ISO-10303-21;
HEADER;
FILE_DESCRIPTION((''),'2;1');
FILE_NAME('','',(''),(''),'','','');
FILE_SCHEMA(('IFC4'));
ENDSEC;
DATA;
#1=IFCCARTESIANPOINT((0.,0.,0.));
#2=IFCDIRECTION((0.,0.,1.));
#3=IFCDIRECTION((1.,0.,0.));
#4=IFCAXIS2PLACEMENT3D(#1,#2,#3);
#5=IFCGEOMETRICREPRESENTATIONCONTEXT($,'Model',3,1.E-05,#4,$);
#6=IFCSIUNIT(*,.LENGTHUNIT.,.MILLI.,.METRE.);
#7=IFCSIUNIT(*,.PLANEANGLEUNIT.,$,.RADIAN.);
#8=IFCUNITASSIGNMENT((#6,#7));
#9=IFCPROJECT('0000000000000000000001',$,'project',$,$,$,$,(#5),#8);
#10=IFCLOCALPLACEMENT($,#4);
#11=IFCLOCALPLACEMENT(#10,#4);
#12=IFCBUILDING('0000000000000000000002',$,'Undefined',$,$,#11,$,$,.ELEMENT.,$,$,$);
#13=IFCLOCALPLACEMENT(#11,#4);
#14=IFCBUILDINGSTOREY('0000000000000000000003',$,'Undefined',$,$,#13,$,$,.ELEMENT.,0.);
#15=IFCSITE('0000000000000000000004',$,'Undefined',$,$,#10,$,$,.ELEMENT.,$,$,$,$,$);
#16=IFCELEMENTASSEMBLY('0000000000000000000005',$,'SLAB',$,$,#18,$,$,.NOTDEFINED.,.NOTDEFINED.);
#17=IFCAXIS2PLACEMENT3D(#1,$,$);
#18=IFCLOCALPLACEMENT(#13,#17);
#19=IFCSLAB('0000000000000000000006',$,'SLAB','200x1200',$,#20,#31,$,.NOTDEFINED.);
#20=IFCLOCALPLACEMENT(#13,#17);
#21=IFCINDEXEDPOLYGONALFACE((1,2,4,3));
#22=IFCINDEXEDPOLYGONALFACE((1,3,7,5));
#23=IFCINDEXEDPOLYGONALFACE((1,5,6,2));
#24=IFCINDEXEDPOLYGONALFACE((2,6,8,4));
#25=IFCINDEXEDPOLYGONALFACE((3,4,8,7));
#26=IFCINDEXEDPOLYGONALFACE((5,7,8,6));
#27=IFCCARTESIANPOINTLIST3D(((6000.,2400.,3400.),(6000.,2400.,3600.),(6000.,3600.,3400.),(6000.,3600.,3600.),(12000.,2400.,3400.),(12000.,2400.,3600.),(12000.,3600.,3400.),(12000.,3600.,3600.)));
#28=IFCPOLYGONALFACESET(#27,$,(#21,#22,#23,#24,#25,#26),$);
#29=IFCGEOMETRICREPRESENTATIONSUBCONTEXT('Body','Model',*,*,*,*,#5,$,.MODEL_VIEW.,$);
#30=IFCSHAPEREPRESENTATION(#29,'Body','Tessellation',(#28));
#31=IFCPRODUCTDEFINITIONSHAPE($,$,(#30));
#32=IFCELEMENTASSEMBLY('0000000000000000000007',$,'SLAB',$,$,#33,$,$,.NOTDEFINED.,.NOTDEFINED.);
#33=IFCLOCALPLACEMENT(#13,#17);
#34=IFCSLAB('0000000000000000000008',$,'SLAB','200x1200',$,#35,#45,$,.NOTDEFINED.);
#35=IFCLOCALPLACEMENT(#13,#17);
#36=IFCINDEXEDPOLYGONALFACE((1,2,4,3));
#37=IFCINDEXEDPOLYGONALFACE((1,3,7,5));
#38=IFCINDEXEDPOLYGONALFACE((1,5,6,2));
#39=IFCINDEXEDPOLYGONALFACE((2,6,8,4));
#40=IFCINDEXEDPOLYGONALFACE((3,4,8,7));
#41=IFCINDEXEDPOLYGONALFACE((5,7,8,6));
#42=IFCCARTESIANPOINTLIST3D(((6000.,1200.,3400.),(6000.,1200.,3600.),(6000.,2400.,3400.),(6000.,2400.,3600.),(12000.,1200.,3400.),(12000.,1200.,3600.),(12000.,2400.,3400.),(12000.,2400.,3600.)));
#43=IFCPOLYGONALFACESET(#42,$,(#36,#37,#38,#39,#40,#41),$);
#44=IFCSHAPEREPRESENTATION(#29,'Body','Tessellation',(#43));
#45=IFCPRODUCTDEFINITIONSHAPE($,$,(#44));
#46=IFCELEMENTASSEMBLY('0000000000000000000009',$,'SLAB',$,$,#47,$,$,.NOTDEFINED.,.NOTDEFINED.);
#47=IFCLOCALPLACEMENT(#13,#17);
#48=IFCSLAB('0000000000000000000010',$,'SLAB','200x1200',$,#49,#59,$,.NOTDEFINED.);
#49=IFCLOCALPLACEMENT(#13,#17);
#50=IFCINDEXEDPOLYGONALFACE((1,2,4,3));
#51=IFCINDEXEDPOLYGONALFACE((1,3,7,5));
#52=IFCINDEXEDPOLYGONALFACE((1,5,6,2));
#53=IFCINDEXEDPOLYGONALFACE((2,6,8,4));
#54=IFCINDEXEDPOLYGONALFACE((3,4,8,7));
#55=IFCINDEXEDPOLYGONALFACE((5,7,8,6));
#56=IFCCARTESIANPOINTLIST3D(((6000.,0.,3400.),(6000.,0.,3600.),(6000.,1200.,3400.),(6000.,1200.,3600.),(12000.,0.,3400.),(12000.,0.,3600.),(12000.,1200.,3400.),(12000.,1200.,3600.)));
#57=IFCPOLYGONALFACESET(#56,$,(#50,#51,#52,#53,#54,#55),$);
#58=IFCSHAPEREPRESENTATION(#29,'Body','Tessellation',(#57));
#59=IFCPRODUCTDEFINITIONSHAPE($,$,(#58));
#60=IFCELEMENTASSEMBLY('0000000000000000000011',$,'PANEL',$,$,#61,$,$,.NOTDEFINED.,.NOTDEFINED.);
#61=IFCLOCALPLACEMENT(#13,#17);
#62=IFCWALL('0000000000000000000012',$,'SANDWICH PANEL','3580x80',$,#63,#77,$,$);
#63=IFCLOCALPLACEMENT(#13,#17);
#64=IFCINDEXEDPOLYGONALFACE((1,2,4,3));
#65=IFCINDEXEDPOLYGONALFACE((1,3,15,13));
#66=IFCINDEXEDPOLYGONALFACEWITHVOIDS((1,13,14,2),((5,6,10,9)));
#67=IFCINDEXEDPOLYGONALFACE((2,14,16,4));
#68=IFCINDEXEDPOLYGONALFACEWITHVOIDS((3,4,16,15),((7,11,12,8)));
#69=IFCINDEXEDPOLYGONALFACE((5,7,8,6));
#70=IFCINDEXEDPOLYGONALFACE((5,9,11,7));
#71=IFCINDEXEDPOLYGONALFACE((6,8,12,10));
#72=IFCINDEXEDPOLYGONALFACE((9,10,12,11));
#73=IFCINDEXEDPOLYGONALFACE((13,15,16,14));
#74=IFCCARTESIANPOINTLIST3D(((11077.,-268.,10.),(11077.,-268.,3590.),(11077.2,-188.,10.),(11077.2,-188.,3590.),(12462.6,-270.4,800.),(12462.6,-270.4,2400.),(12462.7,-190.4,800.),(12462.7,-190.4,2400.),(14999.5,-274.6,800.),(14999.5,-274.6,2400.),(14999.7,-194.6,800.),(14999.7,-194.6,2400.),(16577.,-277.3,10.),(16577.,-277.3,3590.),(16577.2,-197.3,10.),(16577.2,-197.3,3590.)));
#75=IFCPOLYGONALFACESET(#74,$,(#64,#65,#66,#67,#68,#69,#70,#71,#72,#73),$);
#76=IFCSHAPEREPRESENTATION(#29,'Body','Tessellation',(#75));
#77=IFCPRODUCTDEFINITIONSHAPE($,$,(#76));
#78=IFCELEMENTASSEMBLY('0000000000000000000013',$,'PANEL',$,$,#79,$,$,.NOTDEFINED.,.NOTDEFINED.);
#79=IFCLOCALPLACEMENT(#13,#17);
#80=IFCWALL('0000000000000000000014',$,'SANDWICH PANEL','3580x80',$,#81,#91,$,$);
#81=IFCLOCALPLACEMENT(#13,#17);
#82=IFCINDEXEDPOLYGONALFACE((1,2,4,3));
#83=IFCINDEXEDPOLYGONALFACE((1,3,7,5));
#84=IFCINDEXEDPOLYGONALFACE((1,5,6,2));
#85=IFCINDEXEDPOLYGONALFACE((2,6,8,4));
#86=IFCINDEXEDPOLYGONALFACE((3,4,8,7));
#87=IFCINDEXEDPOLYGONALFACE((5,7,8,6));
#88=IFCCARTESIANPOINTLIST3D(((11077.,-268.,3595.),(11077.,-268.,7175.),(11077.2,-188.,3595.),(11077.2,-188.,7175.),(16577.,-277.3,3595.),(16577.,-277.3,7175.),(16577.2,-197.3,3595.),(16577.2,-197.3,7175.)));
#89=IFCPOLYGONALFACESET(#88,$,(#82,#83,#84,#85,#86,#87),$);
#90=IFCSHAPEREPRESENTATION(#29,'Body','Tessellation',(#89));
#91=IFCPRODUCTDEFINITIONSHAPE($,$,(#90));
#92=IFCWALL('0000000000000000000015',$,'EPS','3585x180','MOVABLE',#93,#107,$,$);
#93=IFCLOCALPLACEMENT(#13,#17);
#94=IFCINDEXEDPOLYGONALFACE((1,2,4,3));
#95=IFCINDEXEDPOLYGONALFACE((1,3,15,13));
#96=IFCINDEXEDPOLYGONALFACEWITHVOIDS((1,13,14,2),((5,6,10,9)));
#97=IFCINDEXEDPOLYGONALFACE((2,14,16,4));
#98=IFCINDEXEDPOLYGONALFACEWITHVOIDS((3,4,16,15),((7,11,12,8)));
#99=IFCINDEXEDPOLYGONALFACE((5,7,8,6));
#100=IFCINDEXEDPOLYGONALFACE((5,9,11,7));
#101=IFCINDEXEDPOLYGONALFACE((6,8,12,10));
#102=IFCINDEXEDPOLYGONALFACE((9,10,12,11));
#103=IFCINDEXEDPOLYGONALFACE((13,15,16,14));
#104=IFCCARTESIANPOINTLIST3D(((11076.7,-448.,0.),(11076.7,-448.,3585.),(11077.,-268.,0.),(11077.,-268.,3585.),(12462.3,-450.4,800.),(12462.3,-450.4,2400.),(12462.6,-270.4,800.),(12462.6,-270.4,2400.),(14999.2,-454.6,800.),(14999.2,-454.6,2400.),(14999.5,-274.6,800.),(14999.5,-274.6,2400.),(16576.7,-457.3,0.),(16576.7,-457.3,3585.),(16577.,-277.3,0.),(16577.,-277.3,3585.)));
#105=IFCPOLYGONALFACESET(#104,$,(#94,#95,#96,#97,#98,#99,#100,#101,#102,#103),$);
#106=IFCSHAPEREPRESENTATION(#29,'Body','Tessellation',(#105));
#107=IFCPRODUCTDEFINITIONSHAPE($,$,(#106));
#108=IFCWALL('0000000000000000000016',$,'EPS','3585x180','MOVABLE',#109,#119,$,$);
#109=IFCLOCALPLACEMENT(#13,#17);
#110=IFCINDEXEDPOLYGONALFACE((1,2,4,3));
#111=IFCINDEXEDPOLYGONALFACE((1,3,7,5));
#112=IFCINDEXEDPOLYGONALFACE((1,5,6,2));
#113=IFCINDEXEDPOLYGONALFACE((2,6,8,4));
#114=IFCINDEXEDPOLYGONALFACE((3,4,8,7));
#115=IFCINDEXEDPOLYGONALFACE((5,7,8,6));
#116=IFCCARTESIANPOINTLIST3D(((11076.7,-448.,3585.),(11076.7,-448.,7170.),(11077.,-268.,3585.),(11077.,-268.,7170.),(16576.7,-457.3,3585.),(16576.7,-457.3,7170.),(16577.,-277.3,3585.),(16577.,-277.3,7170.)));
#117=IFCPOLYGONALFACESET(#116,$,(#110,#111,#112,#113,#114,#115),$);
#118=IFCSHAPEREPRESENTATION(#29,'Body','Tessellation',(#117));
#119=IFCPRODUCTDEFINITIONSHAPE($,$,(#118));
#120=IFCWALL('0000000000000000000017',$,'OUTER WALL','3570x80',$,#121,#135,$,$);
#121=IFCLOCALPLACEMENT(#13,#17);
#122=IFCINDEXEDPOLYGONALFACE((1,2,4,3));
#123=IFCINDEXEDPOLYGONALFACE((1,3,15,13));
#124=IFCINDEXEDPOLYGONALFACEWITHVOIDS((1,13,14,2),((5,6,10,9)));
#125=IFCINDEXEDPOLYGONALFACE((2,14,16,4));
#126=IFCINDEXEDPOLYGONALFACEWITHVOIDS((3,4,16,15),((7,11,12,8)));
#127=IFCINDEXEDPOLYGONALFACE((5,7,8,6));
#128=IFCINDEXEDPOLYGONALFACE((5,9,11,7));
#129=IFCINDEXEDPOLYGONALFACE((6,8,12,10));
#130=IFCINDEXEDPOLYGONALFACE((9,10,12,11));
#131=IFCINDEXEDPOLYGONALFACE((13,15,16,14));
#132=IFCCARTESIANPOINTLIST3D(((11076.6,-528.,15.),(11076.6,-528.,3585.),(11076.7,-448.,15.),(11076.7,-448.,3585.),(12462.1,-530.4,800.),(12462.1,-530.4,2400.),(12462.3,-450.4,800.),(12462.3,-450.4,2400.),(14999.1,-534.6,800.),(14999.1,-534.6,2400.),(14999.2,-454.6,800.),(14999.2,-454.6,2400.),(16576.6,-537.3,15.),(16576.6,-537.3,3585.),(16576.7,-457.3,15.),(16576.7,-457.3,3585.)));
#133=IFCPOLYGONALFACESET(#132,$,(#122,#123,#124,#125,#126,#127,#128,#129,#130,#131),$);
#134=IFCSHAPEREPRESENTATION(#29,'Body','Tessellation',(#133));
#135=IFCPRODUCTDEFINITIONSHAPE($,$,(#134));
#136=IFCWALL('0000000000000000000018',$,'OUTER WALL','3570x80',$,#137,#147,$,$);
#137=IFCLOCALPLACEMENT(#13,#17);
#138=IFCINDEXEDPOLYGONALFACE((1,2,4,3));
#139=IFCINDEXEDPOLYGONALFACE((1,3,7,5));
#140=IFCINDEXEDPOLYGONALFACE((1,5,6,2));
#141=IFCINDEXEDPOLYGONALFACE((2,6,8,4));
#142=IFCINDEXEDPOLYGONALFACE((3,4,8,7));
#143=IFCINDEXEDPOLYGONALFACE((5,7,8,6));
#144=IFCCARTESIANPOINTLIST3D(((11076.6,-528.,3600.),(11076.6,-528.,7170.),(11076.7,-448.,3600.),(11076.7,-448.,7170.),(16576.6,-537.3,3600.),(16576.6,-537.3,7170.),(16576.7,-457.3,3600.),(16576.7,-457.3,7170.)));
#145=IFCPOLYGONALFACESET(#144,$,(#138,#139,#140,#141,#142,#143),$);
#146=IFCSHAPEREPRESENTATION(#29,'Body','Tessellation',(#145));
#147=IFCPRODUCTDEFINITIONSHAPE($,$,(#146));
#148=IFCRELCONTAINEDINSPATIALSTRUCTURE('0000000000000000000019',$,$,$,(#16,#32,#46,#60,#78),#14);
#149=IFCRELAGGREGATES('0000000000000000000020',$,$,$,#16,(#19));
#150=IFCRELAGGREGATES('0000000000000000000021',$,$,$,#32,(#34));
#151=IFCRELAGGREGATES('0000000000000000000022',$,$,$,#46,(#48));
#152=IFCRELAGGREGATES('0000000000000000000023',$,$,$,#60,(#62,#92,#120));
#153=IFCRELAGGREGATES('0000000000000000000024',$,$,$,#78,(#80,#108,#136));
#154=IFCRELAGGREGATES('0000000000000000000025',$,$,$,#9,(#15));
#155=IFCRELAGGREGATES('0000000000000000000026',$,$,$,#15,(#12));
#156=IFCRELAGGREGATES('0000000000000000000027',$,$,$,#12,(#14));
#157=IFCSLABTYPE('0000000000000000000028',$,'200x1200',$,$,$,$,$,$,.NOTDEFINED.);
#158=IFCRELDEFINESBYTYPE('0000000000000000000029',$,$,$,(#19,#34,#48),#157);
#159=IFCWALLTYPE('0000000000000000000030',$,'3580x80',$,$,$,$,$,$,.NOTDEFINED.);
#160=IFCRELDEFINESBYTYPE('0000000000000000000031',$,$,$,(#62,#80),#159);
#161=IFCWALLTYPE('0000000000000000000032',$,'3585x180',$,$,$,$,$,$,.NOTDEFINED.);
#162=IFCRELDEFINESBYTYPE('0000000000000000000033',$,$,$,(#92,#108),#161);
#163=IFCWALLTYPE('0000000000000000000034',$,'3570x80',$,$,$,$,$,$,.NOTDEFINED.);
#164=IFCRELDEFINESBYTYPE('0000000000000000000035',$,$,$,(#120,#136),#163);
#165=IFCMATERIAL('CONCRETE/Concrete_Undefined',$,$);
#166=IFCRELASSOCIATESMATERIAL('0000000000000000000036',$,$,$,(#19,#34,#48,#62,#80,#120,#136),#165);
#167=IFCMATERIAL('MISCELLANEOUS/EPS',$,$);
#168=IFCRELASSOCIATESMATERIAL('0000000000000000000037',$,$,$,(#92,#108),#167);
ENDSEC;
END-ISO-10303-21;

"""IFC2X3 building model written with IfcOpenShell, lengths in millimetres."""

from ifc_helpers import new_model, si_unit, frame, frame_2d, origin_with_axes, place, context, subcontext, project, spatial, polyline, rectangle, outline, extrude, material, type_object, element, aggregate, save


model = new_model("IFC2X3")

# Units and contexts
model_context = context("Model", 3, precision=1e-05, world=origin_with_axes())
body_context = subcontext(model_context, "Body", "Model", "MODEL_VIEW")
ifc_project = project(units=[si_unit("LENGTHUNIT", "METRE", prefix="MILLI"), si_unit("PLANEANGLEUNIT", "RADIAN")], contexts=[model_context])

# Site, building, storey
site_placement = place(None, origin_with_axes())
site = spatial("IfcSite", under=ifc_project, at=site_placement, Name="Undefined", CompositionType="ELEMENT")
building_placement = place(site_placement, origin_with_axes())
building = spatial("IfcBuilding", under=site, at=building_placement, Name="Undefined", CompositionType="ELEMENT")
storey_placement = place(building_placement, origin_with_axes())
storey = spatial("IfcBuildingStorey", under=building, at=storey_placement, Name="Undefined", CompositionType="ELEMENT", Elevation=0.0)

# Shared definitions
ifc_material_1 = material(Name="CONCRETE/Concrete_Undefined")

# Element assemblies, slabs
slab_type = type_object("IfcSlabType", Name="200x1200", PredefinedType="NOTDEFINED")
assembly_1_placement = place(storey_placement, origin_with_axes())
assembly_1 = element("IfcElementAssembly", 1, at=assembly_1_placement, inside=storey, Name="SLAB", AssemblyPlace="NOTDEFINED", PredefinedType="NOTDEFINED")
slab_1_placement = place(assembly_1_placement, frame((12000.0, 2400.0, 3500.0), z_axis=(0.0, 0.0, 1.0), x_axis=(0.0, 1.0, 0.0)))
slab_1 = element("IfcSlab", 2, at=slab_1_placement, type_object=slab_type, material=ifc_material_1, Name="SLAB", Description="200x1200", PredefinedType="NOTDEFINED", context=body_context, shape_type="SweptSolid", body=[
    extrude(outline(polyline([(0.0, 0.0), (1200.0, 0.0), (1200.0, 6000.0), (0.0, 6000.0), (0.0, 0.0)])), frame((0.0, 0.0, -100.0), z_axis=(0.0, 0.0, 1.0), x_axis=(1.0, 0.0, 0.0)), (0.0, 0.0, 1.0), 200.0),
])
aggregate(assembly_1, [slab_1])
assembly_2_placement = place(storey_placement, origin_with_axes())
assembly_2 = element("IfcElementAssembly", 3, at=assembly_2_placement, inside=storey, Name="SLAB", AssemblyPlace="NOTDEFINED", PredefinedType="NOTDEFINED")
slab_2_placement = place(assembly_2_placement, frame((12000.0, 1200.0, 3500.0), z_axis=(0.0, 0.0, 1.0), x_axis=(0.0, 1.0, 0.0)))
slab_2 = element("IfcSlab", 4, at=slab_2_placement, type_object=slab_type, material=ifc_material_1, Name="SLAB", Description="200x1200", PredefinedType="NOTDEFINED", context=body_context, shape_type="SweptSolid", body=[
    extrude(outline(polyline([(0.0, 0.0), (1200.0, 0.0), (1200.0, 6000.0), (0.0, 6000.0), (0.0, 0.0)])), frame((0.0, 0.0, -100.0), z_axis=(0.0, 0.0, 1.0), x_axis=(1.0, 0.0, 0.0)), (0.0, 0.0, 1.0), 200.0),
])
aggregate(assembly_2, [slab_2])
assembly_3_placement = place(storey_placement, origin_with_axes())
assembly_3 = element("IfcElementAssembly", 5, at=assembly_3_placement, inside=storey, Name="SLAB", AssemblyPlace="NOTDEFINED", PredefinedType="NOTDEFINED")
slab_3_placement = place(assembly_3_placement, frame((12000.0, 0.0, 3500.0), z_axis=(0.0, 0.0, 1.0), x_axis=(0.0, 1.0, 0.0)))
slab_3 = element("IfcSlab", 6, at=slab_3_placement, type_object=slab_type, material=ifc_material_1, Name="SLAB", Description="200x1200", PredefinedType="NOTDEFINED", context=body_context, shape_type="SweptSolid", body=[
    extrude(outline(polyline([(0.0, 0.0), (1200.0, 0.0), (1200.0, 6000.0), (0.0, 6000.0), (0.0, 0.0)])), frame((0.0, 0.0, -100.0), z_axis=(0.0, 0.0, 1.0), x_axis=(1.0, 0.0, 0.0)), (0.0, 0.0, 1.0), 200.0),
])
aggregate(assembly_3, [slab_3])

# Element assembly, wall, opening
assembly_4_placement = place(storey_placement, origin_with_axes())
assembly_4 = element("IfcElementAssembly", 7, at=assembly_4_placement, inside=storey, Name="PANEL", AssemblyPlace="NOTDEFINED", PredefinedType="NOTDEFINED")
wall_type_1 = type_object("IfcWallType", Name="3580x80", PredefinedType="NOTDEFINED")
wall_1_placement = place(assembly_4_placement, frame((11077.1, -228.0, 10.0), z_axis=(0.0, 0.0, 1.0), x_axis=(0.999999, -0.001684, 0.0)))
wall_1 = element("IfcWall", 8, at=wall_1_placement, type_object=wall_type_1, material=ifc_material_1, Name="SANDWICH PANEL", Description="3580x80", context=body_context, shape_type="SweptSolid", body=[
    extrude(rectangle(XDim=5500.0, YDim=80.0, at=frame_2d((0.0, 2750.0), x_axis=(0.0, -1.0))), frame((0.0, 0.0, 0.0), z_axis=(0.0, 0.0, 1.0), x_axis=(0.0, -1.0, 0.0)), (0.0, 0.0, 1.0), 3580.0),
])
opening_1_placement = place(assembly_4_placement, frame((11077.1, -228.0, 10.0), z_axis=(0.0, 0.0, 1.0), x_axis=(0.999999, -0.001684, 0.0)))
element("IfcOpeningElement", 9, at=opening_1_placement, cuts=wall_1, ObjectType="Recess", context=body_context, shape_type="SweptSolid", body=[
    extrude(outline(polyline([(0.0, 0.0), (2537.0, 0.0), (2537.0, 1600.0), (0.0, 1600.0), (0.0, 0.0)])), frame((1385.5, 90.0, 790.0), z_axis=(0.0, -1.0, 0.0), x_axis=(1.0, 0.0, 0.0)), (0.0, 0.0, 1.0), 180.0),
])

# Element assembly, wall
assembly_5_placement = place(storey_placement, origin_with_axes())
assembly_5 = element("IfcElementAssembly", 10, at=assembly_5_placement, inside=storey, Name="PANEL", AssemblyPlace="NOTDEFINED", PredefinedType="NOTDEFINED")
wall_2_placement = place(assembly_5_placement, frame((11077.1, -228.0, 3595.0), z_axis=(0.0, 0.0, 1.0), x_axis=(0.999999, -0.001684, 0.0)))
wall_2 = element("IfcWall", 11, at=wall_2_placement, type_object=wall_type_1, material=ifc_material_1, Name="SANDWICH PANEL", Description="3580x80", context=body_context, shape_type="SweptSolid", body=[
    extrude(rectangle(XDim=5500.0, YDim=80.0, at=frame_2d((0.0, 2750.0), x_axis=(0.0, -1.0))), frame((0.0, 0.0, 0.0), z_axis=(0.0, 0.0, 1.0), x_axis=(0.0, -1.0, 0.0)), (0.0, 0.0, 1.0), 3580.0),
])

# Wall, opening
ifc_material_2 = material(Name="MISCELLANEOUS/EPS")
wall_type_2 = type_object("IfcWallType", Name="3585x180", PredefinedType="NOTDEFINED")
wall_3_placement = place(assembly_4_placement, frame((11076.9, -358.0, 0.0), z_axis=(0.0, 0.0, 1.0), x_axis=(0.999999, -0.001684, 0.0)))
wall_3 = element("IfcWall", 12, at=wall_3_placement, type_object=wall_type_2, material=ifc_material_2, Name="EPS", Description="3585x180", ObjectType="MOVABLE", context=body_context, shape_type="SweptSolid", body=[
    extrude(rectangle(XDim=5500.0, YDim=180.0, at=frame_2d((0.0, 2750.0), x_axis=(0.0, -1.0))), frame((0.0, 0.0, 0.0), z_axis=(0.0, 0.0, 1.0), x_axis=(0.0, -1.0, 0.0)), (0.0, 0.0, 1.0), 3585.0),
])
opening_2_placement = place(assembly_4_placement, frame((11076.9, -358.0, 0.0), z_axis=(0.0, 0.0, 1.0), x_axis=(0.999999, -0.001684, 0.0)))
element("IfcOpeningElement", 13, at=opening_2_placement, cuts=wall_3, ObjectType="Recess", context=body_context, shape_type="SweptSolid", body=[
    extrude(outline(polyline([(0.0, 0.0), (2537.0, 0.0), (2537.0, 1600.0), (0.0, 1600.0), (0.0, 0.0)])), frame((1385.5, 140.0, 800.0), z_axis=(0.0, -1.0, 0.0), x_axis=(1.0, 0.0, 0.0)), (0.0, 0.0, 1.0), 280.0),
])

# Wall
wall_4_placement = place(assembly_5_placement, frame((11076.9, -358.0, 3585.0), z_axis=(0.0, 0.0, 1.0), x_axis=(0.999999, -0.001684, 0.0)))
wall_4 = element("IfcWall", 14, at=wall_4_placement, type_object=wall_type_2, material=ifc_material_2, Name="EPS", Description="3585x180", ObjectType="MOVABLE", context=body_context, shape_type="SweptSolid", body=[
    extrude(rectangle(XDim=5500.0, YDim=180.0, at=frame_2d((0.0, 2750.0), x_axis=(0.0, -1.0))), frame((0.0, 0.0, 0.0), z_axis=(0.0, 0.0, 1.0), x_axis=(0.0, -1.0, 0.0)), (0.0, 0.0, 1.0), 3585.0),
])

# Wall, opening
wall_type_3 = type_object("IfcWallType", Name="3570x80", PredefinedType="NOTDEFINED")
wall_5_placement = place(assembly_4_placement, frame((11076.7, -488.0, 15.0), z_axis=(0.0, 0.0, 1.0), x_axis=(0.999999, -0.001684, 0.0)))
wall_5 = element("IfcWall", 15, at=wall_5_placement, type_object=wall_type_3, material=ifc_material_1, Name="OUTER WALL", Description="3570x80", context=body_context, shape_type="SweptSolid", body=[
    extrude(rectangle(XDim=5500.0, YDim=80.0, at=frame_2d((0.0, 2750.0), x_axis=(0.0, -1.0))), frame((0.0, 0.0, 0.0), z_axis=(0.0, 0.0, 1.0), x_axis=(0.0, -1.0, 0.0)), (0.0, 0.0, 1.0), 3570.0),
])
opening_3_placement = place(assembly_4_placement, frame((11076.7, -488.0, 15.0), z_axis=(0.0, 0.0, 1.0), x_axis=(0.999999, -0.001684, 0.0)))
element("IfcOpeningElement", 16, at=opening_3_placement, cuts=wall_5, ObjectType="Recess", context=body_context, shape_type="SweptSolid", body=[
    extrude(outline(polyline([(0.0, 0.0), (2537.0, 0.0), (2537.0, 1600.0), (0.0, 1600.0), (0.0, 0.0)])), frame((1385.5, 90.0, 785.0), z_axis=(0.0, -1.0, 0.0), x_axis=(1.0, 0.0, 0.0)), (0.0, 0.0, 1.0), 180.0),
])
aggregate(assembly_4, [wall_1, wall_3, wall_5])

# Wall
wall_6_placement = place(assembly_5_placement, frame((11076.7, -488.0, 3600.0), z_axis=(0.0, 0.0, 1.0), x_axis=(0.999999, -0.001684, 0.0)))
wall_6 = element("IfcWall", 17, at=wall_6_placement, type_object=wall_type_3, material=ifc_material_1, Name="OUTER WALL", Description="3570x80", context=body_context, shape_type="SweptSolid", body=[
    extrude(rectangle(XDim=5500.0, YDim=80.0, at=frame_2d((0.0, 2750.0), x_axis=(0.0, -1.0))), frame((0.0, 0.0, 0.0), z_axis=(0.0, 0.0, 1.0), x_axis=(0.0, -1.0, 0.0)), (0.0, 0.0, 1.0), 3570.0),
])
aggregate(assembly_5, [wall_2, wall_4, wall_6])

save(model, "model.ifc")
